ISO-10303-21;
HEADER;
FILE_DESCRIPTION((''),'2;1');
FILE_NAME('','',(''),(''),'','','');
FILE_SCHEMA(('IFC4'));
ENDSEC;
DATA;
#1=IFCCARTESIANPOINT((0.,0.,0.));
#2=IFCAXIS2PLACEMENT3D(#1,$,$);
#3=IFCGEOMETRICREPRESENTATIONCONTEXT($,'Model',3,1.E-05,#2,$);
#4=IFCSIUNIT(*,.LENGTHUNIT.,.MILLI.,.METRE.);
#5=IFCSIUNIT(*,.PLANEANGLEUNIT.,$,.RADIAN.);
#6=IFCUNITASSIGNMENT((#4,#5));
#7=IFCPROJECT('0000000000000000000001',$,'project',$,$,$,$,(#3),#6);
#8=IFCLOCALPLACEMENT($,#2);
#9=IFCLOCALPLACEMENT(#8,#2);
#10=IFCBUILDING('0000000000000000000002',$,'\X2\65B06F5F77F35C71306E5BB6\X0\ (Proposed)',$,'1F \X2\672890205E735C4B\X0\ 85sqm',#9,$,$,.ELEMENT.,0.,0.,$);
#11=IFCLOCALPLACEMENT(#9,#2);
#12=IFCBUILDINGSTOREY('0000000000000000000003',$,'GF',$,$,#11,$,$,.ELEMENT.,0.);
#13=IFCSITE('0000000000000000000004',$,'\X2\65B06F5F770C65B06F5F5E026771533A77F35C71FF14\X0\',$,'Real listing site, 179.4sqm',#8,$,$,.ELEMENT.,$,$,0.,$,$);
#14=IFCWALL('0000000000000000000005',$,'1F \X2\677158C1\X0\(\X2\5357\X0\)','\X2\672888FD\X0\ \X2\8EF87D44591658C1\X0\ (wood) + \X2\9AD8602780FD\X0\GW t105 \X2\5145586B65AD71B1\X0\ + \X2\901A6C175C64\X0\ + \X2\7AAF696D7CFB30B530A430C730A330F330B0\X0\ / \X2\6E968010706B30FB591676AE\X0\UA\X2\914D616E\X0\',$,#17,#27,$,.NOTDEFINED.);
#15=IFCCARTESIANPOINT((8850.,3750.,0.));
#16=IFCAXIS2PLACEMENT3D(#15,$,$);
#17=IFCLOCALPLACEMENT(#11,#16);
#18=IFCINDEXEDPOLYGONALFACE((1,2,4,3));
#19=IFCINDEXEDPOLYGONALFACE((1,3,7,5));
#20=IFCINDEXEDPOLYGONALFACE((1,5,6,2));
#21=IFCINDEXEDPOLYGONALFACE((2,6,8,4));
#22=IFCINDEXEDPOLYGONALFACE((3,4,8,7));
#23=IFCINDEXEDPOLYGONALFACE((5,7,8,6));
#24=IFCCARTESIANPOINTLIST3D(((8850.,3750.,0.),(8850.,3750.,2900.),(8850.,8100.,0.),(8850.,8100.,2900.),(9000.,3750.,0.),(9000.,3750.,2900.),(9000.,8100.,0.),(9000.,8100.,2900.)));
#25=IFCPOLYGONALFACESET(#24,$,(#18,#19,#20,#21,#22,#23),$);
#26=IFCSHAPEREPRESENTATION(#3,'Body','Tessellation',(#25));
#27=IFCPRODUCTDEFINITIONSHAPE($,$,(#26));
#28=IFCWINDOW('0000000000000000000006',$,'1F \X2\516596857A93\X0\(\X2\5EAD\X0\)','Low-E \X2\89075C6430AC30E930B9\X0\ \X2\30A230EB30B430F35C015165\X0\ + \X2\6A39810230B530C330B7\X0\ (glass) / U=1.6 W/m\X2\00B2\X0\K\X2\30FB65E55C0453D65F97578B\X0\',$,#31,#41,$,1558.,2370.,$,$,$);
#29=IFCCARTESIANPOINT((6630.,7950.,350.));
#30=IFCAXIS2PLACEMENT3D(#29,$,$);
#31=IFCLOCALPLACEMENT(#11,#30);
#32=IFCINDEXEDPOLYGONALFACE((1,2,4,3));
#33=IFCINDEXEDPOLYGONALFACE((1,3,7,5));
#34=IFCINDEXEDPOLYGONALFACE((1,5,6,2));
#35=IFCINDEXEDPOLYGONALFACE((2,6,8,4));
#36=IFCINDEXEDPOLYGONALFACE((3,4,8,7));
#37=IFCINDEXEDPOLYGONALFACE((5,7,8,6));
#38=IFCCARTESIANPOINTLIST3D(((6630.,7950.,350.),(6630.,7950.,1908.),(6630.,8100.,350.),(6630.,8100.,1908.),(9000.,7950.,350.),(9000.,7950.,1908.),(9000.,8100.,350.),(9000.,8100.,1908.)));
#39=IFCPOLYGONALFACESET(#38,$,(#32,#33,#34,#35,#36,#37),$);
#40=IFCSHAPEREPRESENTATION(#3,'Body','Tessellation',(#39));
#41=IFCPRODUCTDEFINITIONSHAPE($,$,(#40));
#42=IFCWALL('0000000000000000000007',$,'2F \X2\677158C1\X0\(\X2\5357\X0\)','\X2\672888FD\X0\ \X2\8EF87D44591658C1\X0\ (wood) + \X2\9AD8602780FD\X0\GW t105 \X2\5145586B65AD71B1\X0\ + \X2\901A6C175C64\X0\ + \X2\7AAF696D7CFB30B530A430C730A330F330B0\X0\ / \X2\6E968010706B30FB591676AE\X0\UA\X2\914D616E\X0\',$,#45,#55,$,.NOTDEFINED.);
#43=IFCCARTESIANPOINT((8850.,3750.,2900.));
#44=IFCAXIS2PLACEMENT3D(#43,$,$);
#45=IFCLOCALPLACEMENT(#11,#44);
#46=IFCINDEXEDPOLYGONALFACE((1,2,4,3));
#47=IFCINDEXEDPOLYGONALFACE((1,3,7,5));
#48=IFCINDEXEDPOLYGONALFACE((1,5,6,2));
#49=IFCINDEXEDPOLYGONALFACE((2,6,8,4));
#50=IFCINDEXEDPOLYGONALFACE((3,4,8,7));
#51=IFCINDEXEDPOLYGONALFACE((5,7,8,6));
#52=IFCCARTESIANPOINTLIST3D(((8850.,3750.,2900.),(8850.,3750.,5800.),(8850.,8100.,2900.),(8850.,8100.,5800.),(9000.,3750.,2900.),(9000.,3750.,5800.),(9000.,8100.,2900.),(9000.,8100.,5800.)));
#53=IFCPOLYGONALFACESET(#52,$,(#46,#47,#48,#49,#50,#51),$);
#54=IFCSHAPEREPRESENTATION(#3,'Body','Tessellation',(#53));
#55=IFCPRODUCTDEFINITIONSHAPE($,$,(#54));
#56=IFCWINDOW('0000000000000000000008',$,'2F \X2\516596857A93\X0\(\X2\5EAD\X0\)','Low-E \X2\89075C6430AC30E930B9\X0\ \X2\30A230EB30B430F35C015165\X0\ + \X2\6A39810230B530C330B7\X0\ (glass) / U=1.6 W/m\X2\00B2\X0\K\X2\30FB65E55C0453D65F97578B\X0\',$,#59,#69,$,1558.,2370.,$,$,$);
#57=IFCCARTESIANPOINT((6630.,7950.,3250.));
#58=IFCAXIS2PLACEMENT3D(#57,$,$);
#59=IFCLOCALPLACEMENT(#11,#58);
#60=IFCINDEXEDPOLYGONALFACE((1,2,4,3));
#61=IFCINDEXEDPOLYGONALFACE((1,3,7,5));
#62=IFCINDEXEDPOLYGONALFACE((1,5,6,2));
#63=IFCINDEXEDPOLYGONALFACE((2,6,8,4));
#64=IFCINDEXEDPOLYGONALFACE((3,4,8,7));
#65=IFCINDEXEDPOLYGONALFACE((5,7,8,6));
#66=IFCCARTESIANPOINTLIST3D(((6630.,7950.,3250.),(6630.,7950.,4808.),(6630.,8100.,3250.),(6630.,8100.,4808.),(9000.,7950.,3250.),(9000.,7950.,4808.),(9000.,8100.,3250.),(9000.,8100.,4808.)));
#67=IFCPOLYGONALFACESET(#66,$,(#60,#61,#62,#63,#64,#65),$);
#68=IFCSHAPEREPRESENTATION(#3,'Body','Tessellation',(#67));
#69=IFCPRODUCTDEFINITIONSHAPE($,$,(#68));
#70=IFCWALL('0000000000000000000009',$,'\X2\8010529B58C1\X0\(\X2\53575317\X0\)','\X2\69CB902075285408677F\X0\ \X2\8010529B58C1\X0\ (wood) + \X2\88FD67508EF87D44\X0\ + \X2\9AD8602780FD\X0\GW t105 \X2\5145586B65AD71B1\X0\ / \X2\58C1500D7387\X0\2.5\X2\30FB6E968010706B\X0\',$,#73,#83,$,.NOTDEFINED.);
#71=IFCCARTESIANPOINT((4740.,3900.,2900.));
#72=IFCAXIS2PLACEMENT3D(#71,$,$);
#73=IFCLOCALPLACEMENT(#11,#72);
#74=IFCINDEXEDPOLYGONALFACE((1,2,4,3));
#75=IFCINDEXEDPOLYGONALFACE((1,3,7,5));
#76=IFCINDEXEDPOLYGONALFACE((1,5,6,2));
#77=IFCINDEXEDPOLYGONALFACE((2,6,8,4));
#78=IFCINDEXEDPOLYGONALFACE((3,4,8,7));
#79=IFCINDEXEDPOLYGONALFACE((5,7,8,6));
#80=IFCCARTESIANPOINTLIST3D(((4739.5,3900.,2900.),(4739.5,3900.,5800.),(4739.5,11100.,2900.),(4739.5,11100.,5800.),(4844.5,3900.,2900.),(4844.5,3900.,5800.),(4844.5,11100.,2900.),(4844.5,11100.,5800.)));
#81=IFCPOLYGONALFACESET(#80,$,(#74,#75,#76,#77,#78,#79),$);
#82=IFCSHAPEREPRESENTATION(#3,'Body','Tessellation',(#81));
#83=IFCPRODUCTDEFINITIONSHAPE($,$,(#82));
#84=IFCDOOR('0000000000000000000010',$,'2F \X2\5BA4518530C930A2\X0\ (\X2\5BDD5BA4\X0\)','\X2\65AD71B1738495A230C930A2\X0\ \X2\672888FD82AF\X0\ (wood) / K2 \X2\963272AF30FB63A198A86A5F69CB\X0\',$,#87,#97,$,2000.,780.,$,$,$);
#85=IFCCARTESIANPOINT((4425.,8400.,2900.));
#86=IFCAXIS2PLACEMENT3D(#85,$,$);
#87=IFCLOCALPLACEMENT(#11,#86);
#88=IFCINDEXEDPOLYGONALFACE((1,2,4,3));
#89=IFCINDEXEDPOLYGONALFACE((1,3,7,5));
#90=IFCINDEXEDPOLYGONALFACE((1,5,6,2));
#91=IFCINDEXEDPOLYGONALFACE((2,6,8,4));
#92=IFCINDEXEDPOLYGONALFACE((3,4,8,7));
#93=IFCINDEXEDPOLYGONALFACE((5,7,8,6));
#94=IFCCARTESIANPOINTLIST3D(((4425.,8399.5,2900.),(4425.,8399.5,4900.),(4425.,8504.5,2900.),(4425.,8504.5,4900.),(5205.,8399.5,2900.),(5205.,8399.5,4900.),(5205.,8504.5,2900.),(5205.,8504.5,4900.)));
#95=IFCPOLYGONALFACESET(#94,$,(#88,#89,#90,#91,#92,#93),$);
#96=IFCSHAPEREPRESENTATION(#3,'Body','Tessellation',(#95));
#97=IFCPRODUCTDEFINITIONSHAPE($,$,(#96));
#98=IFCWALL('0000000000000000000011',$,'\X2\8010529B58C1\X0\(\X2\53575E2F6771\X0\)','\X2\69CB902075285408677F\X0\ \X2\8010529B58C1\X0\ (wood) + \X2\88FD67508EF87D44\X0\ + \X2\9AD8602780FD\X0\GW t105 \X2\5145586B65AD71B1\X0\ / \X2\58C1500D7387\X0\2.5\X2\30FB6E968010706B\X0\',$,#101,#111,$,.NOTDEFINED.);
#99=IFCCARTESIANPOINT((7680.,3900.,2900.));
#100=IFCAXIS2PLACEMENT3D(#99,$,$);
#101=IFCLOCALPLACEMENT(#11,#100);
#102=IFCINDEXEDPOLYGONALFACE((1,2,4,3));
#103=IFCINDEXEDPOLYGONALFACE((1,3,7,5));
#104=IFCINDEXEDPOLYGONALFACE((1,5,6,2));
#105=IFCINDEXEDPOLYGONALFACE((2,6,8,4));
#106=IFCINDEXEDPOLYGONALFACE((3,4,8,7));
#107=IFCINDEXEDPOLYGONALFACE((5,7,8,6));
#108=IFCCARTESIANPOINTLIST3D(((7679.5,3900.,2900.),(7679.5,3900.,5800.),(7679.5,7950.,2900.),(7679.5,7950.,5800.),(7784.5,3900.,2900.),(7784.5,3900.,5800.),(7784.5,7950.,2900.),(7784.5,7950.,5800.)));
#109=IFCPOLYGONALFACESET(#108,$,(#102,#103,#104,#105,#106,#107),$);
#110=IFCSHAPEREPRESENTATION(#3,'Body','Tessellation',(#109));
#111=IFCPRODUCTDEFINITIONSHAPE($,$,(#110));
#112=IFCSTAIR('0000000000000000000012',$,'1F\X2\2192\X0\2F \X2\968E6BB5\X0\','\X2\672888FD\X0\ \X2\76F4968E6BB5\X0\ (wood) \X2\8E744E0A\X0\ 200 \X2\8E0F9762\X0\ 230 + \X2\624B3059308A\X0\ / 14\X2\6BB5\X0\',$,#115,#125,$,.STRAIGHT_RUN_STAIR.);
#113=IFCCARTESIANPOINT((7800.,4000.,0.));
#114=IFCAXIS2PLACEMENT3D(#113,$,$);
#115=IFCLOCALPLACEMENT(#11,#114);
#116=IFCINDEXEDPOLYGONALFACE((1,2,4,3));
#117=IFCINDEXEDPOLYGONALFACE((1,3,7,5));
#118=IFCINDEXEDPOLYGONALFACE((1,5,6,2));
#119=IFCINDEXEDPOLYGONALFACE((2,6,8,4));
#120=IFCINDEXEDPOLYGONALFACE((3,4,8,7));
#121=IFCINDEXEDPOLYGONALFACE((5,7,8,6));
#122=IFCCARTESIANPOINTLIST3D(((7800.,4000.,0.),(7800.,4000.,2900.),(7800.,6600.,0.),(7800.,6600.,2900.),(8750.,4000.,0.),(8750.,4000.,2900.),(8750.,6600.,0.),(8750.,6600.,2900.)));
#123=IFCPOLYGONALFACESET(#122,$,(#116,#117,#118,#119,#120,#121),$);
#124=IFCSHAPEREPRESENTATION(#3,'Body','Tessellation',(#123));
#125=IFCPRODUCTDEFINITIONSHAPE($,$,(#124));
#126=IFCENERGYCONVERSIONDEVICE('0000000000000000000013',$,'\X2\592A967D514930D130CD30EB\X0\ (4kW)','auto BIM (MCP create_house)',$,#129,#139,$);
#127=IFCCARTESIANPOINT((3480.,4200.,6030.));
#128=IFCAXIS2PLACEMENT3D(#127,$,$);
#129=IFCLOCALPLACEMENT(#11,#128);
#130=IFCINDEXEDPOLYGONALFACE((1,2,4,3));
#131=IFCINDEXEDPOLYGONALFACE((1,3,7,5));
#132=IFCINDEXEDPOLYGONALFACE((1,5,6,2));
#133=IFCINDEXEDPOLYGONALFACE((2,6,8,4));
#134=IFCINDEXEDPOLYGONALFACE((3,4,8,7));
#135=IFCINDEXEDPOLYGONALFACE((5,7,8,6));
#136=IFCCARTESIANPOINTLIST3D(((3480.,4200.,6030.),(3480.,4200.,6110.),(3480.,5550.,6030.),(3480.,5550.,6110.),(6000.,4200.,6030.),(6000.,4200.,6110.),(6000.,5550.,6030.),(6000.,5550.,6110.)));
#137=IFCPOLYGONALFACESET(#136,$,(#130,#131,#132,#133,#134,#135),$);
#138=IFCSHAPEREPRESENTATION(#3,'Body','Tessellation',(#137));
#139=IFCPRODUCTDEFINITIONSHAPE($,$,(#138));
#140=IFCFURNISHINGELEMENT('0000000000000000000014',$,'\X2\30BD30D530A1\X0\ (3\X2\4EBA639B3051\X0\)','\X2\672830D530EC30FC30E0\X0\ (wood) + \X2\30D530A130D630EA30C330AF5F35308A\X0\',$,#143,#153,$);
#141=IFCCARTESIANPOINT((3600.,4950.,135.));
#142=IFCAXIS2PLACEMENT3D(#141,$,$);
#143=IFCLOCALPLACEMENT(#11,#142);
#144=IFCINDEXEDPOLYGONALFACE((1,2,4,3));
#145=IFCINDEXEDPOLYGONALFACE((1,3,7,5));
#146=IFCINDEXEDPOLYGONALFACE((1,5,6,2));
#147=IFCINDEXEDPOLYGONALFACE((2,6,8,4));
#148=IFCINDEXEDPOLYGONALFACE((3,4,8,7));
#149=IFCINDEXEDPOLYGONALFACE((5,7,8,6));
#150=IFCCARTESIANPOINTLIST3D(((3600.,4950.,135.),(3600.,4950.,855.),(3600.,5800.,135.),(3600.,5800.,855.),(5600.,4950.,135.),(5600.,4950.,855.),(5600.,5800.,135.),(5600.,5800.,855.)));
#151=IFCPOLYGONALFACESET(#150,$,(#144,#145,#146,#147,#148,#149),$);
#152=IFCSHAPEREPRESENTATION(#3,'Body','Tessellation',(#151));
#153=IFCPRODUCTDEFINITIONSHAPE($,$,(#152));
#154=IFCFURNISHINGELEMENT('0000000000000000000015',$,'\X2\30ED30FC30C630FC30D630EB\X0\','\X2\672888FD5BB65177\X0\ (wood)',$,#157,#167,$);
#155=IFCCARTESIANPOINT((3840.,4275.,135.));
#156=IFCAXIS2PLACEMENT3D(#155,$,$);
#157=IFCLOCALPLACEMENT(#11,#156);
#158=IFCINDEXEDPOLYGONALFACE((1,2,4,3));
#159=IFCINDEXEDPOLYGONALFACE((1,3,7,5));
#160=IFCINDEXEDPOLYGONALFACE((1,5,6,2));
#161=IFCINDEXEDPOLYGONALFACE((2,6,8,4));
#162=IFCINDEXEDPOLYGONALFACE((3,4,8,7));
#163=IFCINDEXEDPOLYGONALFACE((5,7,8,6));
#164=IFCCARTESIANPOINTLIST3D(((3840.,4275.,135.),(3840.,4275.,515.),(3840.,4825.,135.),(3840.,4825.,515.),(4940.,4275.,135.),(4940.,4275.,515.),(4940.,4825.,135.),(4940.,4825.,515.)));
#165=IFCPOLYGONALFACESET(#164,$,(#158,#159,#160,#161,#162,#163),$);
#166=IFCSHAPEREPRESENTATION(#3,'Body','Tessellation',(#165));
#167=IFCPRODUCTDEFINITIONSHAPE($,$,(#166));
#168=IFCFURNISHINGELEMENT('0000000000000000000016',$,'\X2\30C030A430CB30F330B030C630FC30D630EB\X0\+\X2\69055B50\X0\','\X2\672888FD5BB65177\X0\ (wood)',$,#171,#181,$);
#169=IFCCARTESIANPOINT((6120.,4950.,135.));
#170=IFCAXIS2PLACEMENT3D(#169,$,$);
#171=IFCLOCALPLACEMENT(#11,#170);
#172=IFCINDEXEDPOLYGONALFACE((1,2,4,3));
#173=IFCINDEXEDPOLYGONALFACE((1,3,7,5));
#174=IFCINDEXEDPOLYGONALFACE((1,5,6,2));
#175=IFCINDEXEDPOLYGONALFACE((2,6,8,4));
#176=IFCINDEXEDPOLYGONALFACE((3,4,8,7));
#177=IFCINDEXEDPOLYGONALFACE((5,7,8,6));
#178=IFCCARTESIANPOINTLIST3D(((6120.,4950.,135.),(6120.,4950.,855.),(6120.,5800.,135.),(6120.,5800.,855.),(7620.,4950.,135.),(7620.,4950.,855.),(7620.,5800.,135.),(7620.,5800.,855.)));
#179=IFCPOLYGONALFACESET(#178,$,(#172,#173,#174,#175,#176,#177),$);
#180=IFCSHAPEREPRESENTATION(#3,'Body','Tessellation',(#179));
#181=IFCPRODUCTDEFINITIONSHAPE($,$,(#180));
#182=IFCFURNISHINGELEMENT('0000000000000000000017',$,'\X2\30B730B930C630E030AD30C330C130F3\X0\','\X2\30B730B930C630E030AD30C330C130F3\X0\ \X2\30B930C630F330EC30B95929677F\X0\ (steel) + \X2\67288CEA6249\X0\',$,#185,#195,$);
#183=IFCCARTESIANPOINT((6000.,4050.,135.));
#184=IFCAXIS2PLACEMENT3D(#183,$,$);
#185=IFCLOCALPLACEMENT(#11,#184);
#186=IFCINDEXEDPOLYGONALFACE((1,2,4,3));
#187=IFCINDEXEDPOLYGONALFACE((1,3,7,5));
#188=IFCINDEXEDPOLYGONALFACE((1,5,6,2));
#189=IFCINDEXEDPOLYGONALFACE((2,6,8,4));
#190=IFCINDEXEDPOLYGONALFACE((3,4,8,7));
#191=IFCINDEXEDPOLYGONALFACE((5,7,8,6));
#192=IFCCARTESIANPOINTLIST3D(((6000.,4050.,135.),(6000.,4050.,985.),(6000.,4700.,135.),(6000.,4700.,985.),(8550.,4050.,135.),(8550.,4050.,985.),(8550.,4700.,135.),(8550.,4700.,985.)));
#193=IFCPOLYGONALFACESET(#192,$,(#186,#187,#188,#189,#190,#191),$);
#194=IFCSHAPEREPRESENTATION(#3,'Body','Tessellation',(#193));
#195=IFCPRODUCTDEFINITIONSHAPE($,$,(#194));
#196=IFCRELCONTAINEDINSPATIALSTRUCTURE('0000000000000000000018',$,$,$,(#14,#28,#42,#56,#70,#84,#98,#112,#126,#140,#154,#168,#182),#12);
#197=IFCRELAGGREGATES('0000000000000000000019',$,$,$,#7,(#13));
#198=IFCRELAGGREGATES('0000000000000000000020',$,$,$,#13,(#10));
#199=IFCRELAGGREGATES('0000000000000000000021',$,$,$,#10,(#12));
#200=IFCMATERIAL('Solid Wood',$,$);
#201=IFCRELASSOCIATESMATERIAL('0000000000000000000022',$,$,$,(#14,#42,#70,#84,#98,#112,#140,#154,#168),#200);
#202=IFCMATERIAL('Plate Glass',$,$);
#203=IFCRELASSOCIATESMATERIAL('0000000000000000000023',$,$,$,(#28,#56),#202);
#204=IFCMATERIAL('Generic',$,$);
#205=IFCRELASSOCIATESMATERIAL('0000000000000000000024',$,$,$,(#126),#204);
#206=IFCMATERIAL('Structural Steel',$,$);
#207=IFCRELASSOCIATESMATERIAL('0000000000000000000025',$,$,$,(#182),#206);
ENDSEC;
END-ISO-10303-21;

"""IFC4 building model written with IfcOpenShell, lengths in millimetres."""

from ifc_helpers import new_model, si_unit, frame, frame_2d, origin, place, context, project, spatial, rectangle, extrude, material, element, fill, save


model = new_model("IFC4")

# Units and contexts
model_context = context("Model", 3, precision=1e-05, world=origin())
ifc_project = project(units=[si_unit("LENGTHUNIT", "METRE", prefix="MILLI"), si_unit("PLANEANGLEUNIT", "RADIAN")], contexts=[model_context])

# Site, building, storey
site_placement = place(None, origin())
site = spatial("IfcSite", under=ifc_project, at=site_placement, Name="新潟県新潟市東区石山４", ObjectType="Real listing site, 179.4sqm", CompositionType="ELEMENT", RefElevation=0.0)
building_placement = place(site_placement, origin())
building = spatial("IfcBuilding", under=site, at=building_placement, Name="新潟石山の家 (Proposed)", ObjectType="1F 木造平屋 85sqm", CompositionType="ELEMENT", ElevationOfRefHeight=0.0, ElevationOfTerrain=0.0)
storey_placement = place(building_placement, origin())
storey = spatial("IfcBuildingStorey", under=building, at=storey_placement, Name="GF", CompositionType="ELEMENT", Elevation=0.0)

# Wall, opening, window
ifc_material_1 = material(Name="Solid Wood")
wall_1_placement = place(storey_placement, frame((8850.0, 3750.0, 0.0)))
wall_1 = element("IfcWall", 1, at=wall_1_placement, inside=storey, material=ifc_material_1, Name="1F 東壁(南)", Description="木製 軸組外壁 (wood) + 高性能GW t105 充填断熱 + 通気層 + 窯業系サイディング / 準耐火・外皮UA配慮", PredefinedType="NOTDEFINED", context=model_context, shape_type="SweptSolid", body=[
    extrude(rectangle(XDim=150.0, YDim=4350.0, at=frame_2d((75.0, 2175.0))), frame((8850.0, 3750.0, 0.0)), (0.0, 0.0, 1.0), 2900.0),
])
opening_1_placement = place(storey_placement, frame((6630.0, 7950.0, 350.0)))
opening_1 = element("IfcOpeningElement", 2, at=opening_1_placement, cuts=wall_1, PredefinedType="NOTDEFINED", context=model_context, shape_type="SweptSolid", body=[
    extrude(rectangle(XDim=2370.0, YDim=150.0, at=frame_2d((1185.0, 75.0))), frame((6630.0, 7950.0, 350.0)), (0.0, 0.0, 1.0), 1558.0),
])
ifc_material_2 = material(Name="Plate Glass")
window_1_placement = place(storey_placement, frame((6630.0, 7950.0, 350.0)))
window_1 = element("IfcWindow", 3, at=window_1_placement, inside=storey, material=ifc_material_2, Name="1F 入隅窓(庭)", Description="Low-E 複層ガラス アルゴン封入 + 樹脂サッシ (glass) / U=1.6 W/m²K・日射取得型", OverallHeight=1558.0, OverallWidth=2370.0, context=model_context, shape_type="SweptSolid", body=[
    extrude(rectangle(XDim=2370.0, YDim=150.0, at=frame_2d((1185.0, 75.0))), frame((6630.0, 7950.0, 350.0)), (0.0, 0.0, 1.0), 1558.0),
])
fill(opening_1, window_1)

# Wall, opening, window
wall_2_placement = place(storey_placement, frame((8850.0, 3750.0, 2900.0)))
wall_2 = element("IfcWall", 4, at=wall_2_placement, inside=storey, material=ifc_material_1, Name="2F 東壁(南)", Description="木製 軸組外壁 (wood) + 高性能GW t105 充填断熱 + 通気層 + 窯業系サイディング / 準耐火・外皮UA配慮", PredefinedType="NOTDEFINED", context=model_context, shape_type="SweptSolid", body=[
    extrude(rectangle(XDim=150.0, YDim=4350.0, at=frame_2d((75.0, 2175.0))), frame((8850.0, 3750.0, 2900.0)), (0.0, 0.0, 1.0), 2900.0),
])
opening_2_placement = place(storey_placement, frame((6630.0, 7950.0, 3250.0)))
opening_2 = element("IfcOpeningElement", 5, at=opening_2_placement, cuts=wall_2, PredefinedType="NOTDEFINED", context=model_context, shape_type="SweptSolid", body=[
    extrude(rectangle(XDim=2370.0, YDim=150.0, at=frame_2d((1185.0, 75.0))), frame((6630.0, 7950.0, 3250.0)), (0.0, 0.0, 1.0), 1558.0),
])
window_2_placement = place(storey_placement, frame((6630.0, 7950.0, 3250.0)))
window_2 = element("IfcWindow", 6, at=window_2_placement, inside=storey, material=ifc_material_2, Name="2F 入隅窓(庭)", Description="Low-E 複層ガラス アルゴン封入 + 樹脂サッシ (glass) / U=1.6 W/m²K・日射取得型", OverallHeight=1558.0, OverallWidth=2370.0, context=model_context, shape_type="SweptSolid", body=[
    extrude(rectangle(XDim=2370.0, YDim=150.0, at=frame_2d((1185.0, 75.0))), frame((6630.0, 7950.0, 3250.0)), (0.0, 0.0, 1.0), 1558.0),
])
fill(opening_2, window_2)

# Wall, opening, door
wall_3_placement = place(storey_placement, frame((4740.0, 3900.0, 2900.0)))
wall_3 = element("IfcWall", 7, at=wall_3_placement, inside=storey, material=ifc_material_1, Name="耐力壁(南北)", Description="構造用合板 耐力壁 (wood) + 製材軸組 + 高性能GW t105 充填断熱 / 壁倍率2.5・準耐火", PredefinedType="NOTDEFINED", context=model_context, shape_type="SweptSolid", body=[
    extrude(rectangle(XDim=105.0, YDim=7200.0, at=frame_2d((52.0, 3600.0))), frame((4740.0, 3900.0, 2900.0)), (0.0, 0.0, 1.0), 2900.0),
])
opening_3_placement = place(storey_placement, frame((4425.0, 8400.0, 2900.0)))
opening_3 = element("IfcOpeningElement", 8, at=opening_3_placement, cuts=wall_3, PredefinedType="NOTDEFINED", context=model_context, shape_type="SweptSolid", body=[
    extrude(rectangle(XDim=780.0, YDim=105.0, at=frame_2d((390.0, 52.0))), frame((4425.0, 8400.0, 2900.0)), (0.0, 0.0, 1.0), 2000.0),
])
door_1_placement = place(storey_placement, frame((4425.0, 8400.0, 2900.0)))
door_1 = element("IfcDoor", 9, at=door_1_placement, inside=storey, material=ifc_material_1, Name="2F 室内ドア (寝室)", Description="断熱玄関ドア 木製芯 (wood) / K2 防犯・採風機構", OverallHeight=2000.0, OverallWidth=780.0, context=model_context, shape_type="SweptSolid", body=[
    extrude(rectangle(XDim=780.0, YDim=105.0, at=frame_2d((390.0, 52.0))), frame((4425.0, 8400.0, 2900.0)), (0.0, 0.0, 1.0), 2000.0),
])
fill(opening_3, door_1)

# Wall
wall_4_placement = place(storey_placement, frame((7680.0, 3900.0, 2900.0)))
element("IfcWall", 10, at=wall_4_placement, inside=storey, material=ifc_material_1, Name="耐力壁(南帯東)", Description="構造用合板 耐力壁 (wood) + 製材軸組 + 高性能GW t105 充填断熱 / 壁倍率2.5・準耐火", PredefinedType="NOTDEFINED", context=model_context, shape_type="SweptSolid", body=[
    extrude(rectangle(XDim=105.0, YDim=4050.0, at=frame_2d((52.0, 2025.0))), frame((7680.0, 3900.0, 2900.0)), (0.0, 0.0, 1.0), 2900.0),
])

# Stair
stair_placement = place(storey_placement, frame((7800.0, 4000.0, 0.0)))
element("IfcStair", 11, at=stair_placement, inside=storey, material=ifc_material_1, Name="1F→2F 階段", Description="木製 直階段 (wood) 蹴上 200 踏面 230 + 手すり / 14段", PredefinedType="STRAIGHT_RUN_STAIR", context=model_context, shape_type="SweptSolid", body=[
    extrude(rectangle(XDim=950.0, YDim=2600.0, at=frame_2d((475.0, 1300.0))), frame((7800.0, 4000.0, 0.0)), (0.0, 0.0, 1.0), 2900.0),
])

# Energy conversion device
ifc_material_3 = material(Name="Generic")
energy_conversion_device_placement = place(storey_placement, frame((3480.0, 4200.0, 6030.0)))
element("IfcEnergyConversionDevice", 12, at=energy_conversion_device_placement, inside=storey, material=ifc_material_3, Name="太陽光パネル (4kW)", Description="auto BIM (MCP create_house)", context=model_context, shape_type="SweptSolid", body=[
    extrude(rectangle(XDim=2520.0, YDim=1350.0, at=frame_2d((1260.0, 675.0))), frame((3480.0, 4200.0, 6030.0)), (0.0, 0.0, 1.0), 80.0),
])

# Furnishing elements
furnishing_1_placement = place(storey_placement, frame((3600.0, 4950.0, 135.0)))
element("IfcFurnishingElement", 13, at=furnishing_1_placement, inside=storey, material=ifc_material_1, Name="ソファ (3人掛け)", Description="木フレーム (wood) + ファブリック張り", context=model_context, shape_type="SweptSolid", body=[
    extrude(rectangle(XDim=2000.0, YDim=850.0, at=frame_2d((1000.0, 425.0))), frame((3600.0, 4950.0, 135.0)), (0.0, 0.0, 1.0), 720.0),
])
furnishing_2_placement = place(storey_placement, frame((3840.0, 4275.0, 135.0)))
element("IfcFurnishingElement", 14, at=furnishing_2_placement, inside=storey, material=ifc_material_1, Name="ローテーブル", Description="木製家具 (wood)", context=model_context, shape_type="SweptSolid", body=[
    extrude(rectangle(XDim=1100.0, YDim=550.0, at=frame_2d((550.0, 275.0))), frame((3840.0, 4275.0, 135.0)), (0.0, 0.0, 1.0), 380.0),
])
furnishing_3_placement = place(storey_placement, frame((6120.0, 4950.0, 135.0)))
element("IfcFurnishingElement", 15, at=furnishing_3_placement, inside=storey, material=ifc_material_1, Name="ダイニングテーブル+椅子", Description="木製家具 (wood)", context=model_context, shape_type="SweptSolid", body=[
    extrude(rectangle(XDim=1500.0, YDim=850.0, at=frame_2d((750.0, 425.0))), frame((6120.0, 4950.0, 135.0)), (0.0, 0.0, 1.0), 720.0),
])
ifc_material_4 = material(Name="Structural Steel")
furnishing_4_placement = place(storey_placement, frame((6000.0, 4050.0, 135.0)))
element("IfcFurnishingElement", 16, at=furnishing_4_placement, inside=storey, material=ifc_material_4, Name="システムキッチン", Description="システムキッチン ステンレス天板 (steel) + 木質扉", context=model_context, shape_type="SweptSolid", body=[
    extrude(rectangle(XDim=2550.0, YDim=650.0, at=frame_2d((1275.0, 325.0))), frame((6000.0, 4050.0, 135.0)), (0.0, 0.0, 1.0), 850.0),
])

save(model, "model.ifc")
